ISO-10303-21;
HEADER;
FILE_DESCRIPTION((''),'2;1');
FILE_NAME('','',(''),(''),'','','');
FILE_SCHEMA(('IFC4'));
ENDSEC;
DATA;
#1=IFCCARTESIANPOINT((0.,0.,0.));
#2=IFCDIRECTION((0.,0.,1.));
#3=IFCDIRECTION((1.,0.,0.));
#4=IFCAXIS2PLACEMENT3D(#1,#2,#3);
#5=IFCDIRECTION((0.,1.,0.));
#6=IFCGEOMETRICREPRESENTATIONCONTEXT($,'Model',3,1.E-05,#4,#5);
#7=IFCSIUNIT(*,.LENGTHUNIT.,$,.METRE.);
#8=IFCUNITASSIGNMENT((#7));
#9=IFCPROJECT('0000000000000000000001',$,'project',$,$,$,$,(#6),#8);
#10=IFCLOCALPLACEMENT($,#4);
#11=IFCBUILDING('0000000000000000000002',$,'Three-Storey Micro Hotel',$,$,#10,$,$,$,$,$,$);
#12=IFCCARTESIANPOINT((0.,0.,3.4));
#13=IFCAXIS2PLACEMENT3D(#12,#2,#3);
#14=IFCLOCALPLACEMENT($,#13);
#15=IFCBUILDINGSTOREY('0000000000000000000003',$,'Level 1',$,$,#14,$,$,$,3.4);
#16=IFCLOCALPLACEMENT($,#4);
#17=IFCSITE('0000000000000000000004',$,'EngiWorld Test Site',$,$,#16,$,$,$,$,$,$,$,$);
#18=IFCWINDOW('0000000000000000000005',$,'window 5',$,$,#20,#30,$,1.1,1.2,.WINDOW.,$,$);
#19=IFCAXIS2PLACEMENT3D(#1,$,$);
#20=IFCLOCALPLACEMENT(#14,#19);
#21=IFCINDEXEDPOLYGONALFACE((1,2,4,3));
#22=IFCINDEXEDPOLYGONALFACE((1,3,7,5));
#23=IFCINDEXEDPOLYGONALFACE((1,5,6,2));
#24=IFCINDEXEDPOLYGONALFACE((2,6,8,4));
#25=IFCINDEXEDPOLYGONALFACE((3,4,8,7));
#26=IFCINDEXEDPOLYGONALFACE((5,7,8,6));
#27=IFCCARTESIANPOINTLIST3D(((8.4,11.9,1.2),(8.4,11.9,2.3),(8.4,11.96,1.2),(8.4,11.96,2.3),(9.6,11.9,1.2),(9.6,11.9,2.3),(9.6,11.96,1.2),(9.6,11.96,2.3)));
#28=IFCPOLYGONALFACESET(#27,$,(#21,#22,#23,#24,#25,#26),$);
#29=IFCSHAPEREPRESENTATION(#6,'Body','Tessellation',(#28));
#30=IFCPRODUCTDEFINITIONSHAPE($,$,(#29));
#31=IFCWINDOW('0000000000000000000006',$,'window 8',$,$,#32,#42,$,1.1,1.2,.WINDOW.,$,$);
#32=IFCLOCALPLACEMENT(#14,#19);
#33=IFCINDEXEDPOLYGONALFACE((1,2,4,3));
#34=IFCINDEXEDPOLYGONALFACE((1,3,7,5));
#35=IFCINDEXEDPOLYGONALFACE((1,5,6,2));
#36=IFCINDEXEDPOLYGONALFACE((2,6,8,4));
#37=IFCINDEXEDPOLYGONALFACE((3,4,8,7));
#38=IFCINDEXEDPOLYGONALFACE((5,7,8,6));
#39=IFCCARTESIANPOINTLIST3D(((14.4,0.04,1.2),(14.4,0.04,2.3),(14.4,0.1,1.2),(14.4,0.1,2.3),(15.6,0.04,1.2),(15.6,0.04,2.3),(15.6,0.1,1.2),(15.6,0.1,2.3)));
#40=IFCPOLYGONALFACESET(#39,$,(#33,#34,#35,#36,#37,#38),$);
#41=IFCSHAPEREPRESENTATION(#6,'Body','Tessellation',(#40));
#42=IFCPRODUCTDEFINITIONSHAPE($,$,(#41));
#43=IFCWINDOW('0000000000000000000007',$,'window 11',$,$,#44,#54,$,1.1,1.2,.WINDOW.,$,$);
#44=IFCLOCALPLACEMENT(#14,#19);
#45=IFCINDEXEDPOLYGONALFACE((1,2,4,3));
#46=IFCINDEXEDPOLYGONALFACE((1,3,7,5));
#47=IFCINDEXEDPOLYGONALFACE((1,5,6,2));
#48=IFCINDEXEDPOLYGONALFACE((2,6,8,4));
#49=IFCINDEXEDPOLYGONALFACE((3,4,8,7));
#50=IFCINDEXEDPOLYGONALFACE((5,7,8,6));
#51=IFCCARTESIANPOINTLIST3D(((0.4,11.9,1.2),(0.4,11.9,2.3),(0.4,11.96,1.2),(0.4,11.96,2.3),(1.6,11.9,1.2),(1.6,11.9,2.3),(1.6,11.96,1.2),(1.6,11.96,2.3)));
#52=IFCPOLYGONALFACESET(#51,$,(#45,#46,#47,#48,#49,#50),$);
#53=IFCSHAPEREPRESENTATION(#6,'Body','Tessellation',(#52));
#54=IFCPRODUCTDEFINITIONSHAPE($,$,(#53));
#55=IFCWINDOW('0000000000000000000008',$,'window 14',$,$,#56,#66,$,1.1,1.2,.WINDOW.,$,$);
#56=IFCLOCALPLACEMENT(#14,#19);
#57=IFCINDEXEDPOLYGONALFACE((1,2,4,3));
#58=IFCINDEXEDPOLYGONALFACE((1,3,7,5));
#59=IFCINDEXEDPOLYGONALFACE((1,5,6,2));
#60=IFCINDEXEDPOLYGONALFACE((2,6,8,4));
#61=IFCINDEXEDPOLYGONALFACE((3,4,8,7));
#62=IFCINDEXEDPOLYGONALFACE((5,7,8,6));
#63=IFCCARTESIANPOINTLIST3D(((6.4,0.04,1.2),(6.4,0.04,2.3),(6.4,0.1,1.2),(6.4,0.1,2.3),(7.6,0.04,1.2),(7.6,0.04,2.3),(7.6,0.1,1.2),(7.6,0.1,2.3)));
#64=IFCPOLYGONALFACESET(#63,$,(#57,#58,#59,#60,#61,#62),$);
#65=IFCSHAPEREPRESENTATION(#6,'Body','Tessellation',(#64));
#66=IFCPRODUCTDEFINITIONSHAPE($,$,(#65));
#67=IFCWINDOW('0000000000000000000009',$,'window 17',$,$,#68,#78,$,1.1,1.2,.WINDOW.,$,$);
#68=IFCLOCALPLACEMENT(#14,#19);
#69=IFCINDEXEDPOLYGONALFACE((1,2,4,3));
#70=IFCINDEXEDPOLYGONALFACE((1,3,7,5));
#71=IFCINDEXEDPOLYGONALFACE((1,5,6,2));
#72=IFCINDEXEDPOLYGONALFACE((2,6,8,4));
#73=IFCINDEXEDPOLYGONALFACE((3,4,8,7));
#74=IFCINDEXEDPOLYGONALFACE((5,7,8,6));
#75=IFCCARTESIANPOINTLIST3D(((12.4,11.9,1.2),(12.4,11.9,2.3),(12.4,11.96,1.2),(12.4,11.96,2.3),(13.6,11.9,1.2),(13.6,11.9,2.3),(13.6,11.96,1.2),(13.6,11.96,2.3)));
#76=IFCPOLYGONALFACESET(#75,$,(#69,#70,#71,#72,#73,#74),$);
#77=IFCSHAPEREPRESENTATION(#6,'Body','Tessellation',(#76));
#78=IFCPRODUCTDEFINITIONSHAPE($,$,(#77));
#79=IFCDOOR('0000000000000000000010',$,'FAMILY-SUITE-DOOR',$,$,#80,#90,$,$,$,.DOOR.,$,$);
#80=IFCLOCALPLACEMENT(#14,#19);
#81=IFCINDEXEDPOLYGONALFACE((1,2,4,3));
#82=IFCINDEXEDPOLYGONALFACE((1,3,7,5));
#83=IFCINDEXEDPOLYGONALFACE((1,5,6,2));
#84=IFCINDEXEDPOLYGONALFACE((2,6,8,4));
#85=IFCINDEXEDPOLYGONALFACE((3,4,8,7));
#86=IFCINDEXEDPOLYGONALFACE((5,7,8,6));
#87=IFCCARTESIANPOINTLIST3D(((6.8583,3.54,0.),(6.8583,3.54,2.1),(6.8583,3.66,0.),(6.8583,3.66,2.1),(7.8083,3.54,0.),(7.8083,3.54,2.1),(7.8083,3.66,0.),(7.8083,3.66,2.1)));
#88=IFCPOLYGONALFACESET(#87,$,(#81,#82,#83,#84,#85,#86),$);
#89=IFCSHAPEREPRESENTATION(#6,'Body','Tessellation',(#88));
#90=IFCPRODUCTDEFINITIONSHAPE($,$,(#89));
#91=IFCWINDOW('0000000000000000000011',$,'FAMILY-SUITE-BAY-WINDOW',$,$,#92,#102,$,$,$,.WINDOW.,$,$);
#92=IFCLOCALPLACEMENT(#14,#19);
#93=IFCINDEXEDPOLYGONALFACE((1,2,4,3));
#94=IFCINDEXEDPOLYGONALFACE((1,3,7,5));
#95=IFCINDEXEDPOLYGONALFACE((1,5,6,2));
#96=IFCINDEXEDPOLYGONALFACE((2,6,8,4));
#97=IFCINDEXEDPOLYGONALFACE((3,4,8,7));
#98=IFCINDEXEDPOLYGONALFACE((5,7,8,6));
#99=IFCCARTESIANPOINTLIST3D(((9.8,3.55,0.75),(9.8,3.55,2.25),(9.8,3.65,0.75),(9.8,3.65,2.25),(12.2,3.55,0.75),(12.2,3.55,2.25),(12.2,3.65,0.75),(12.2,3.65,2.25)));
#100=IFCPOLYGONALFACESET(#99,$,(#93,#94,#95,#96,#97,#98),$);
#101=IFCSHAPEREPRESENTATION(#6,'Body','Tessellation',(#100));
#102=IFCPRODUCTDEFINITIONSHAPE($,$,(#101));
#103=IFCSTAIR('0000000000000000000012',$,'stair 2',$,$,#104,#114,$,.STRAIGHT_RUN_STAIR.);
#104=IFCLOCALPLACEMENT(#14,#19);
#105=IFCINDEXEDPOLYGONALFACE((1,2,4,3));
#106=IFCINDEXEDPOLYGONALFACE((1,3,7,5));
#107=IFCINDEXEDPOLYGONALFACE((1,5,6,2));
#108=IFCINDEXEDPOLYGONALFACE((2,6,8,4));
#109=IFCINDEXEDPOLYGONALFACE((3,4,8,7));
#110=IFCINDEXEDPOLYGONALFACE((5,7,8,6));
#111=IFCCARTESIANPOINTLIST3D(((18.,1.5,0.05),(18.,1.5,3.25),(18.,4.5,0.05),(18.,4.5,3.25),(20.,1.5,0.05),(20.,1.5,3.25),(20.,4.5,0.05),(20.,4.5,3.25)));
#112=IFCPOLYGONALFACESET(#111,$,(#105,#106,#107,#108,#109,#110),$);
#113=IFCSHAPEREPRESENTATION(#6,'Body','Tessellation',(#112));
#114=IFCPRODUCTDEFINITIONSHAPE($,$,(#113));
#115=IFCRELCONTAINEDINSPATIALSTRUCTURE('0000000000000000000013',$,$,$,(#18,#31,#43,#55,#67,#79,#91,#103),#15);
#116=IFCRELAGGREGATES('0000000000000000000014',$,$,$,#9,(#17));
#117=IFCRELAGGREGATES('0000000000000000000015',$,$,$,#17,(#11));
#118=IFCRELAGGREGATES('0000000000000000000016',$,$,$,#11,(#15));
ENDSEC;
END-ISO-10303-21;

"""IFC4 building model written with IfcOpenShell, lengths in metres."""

from ifc_helpers import new_model, si_unit, direction, frame, origin, origin_with_axes, origin_2d, origin_2d_with_axis, place, context, project, spatial, rectangle, extrude, element, save


model = new_model("IFC4")

# Units and contexts
model_context = context("Model", 3, precision=1e-05, world=origin_with_axes(), true_north=direction((0.0, 1.0, 0.0)))
ifc_project = project(units=[si_unit("LENGTHUNIT", "METRE")], contexts=[model_context])

# Site, building, storey
site_placement = place(None, origin_with_axes())
site = spatial("IfcSite", under=ifc_project, at=site_placement, Name="EngiWorld Test Site")
building_placement = place(None, origin_with_axes())
building = spatial("IfcBuilding", under=site, at=building_placement, Name="Three-Storey Micro Hotel")
storey_placement = place(None, frame((0.0, 0.0, 3.4), z_axis=(0.0, 0.0, 1.0), x_axis=(1.0, 0.0, 0.0)))
storey = spatial("IfcBuildingStorey", under=building, at=storey_placement, Name="Level 1", Elevation=3.4)

# Windows
for number, where, z_axis, x_axis, name in (
    (1, (9.0, 11.93, 4.6), (0.0, 0.0, 1.0), (1.0, 0.0, 0.0), "window 5"),
    (2, (15.0, 0.07, 4.6), (0.0, 0.0, 1.0), (1.0, 0.0, 0.0), "window 8"),
    (3, (1.0, 11.93, 4.6), (0.0, 0.0, 1.0), (1.0, 0.0, 0.0), "window 11"),
    (4, (7.0, 0.07, 4.6), (0.0, 0.0, 1.0), (1.0, 0.0, 0.0), "window 14"),
    (5, (13.0, 11.93, 4.6), (0.0, 0.0, 1.0), (1.0, 0.0, 0.0), "window 17"),
):
    element("IfcWindow", number, at=place(None, frame(where, z_axis=z_axis, x_axis=x_axis)), inside=storey, Name=name, OverallHeight=1.1, OverallWidth=1.2, PredefinedType="WINDOW", context=model_context, shape_type="SweptSolid", body=[
        extrude(rectangle(XDim=1.2, YDim=0.06, at=origin_2d_with_axis()), origin_with_axes(), (0.0, 0.0, 1.0), 1.1),
    ])

# Door
door_placement = place(None, frame((7.3333, 3.6, 3.4)))
element("IfcDoor", 6, at=door_placement, inside=storey, Name="FAMILY-SUITE-DOOR", PredefinedType="DOOR", context=model_context, shape_type="SweptSolid", body=[
    extrude(rectangle(XDim=0.95, YDim=0.12, at=origin_2d()), origin(), (0.0, 0.0, 1.0), 2.1),
])

# Window
window_placement = place(None, frame((11.0, 3.6, 4.15)))
element("IfcWindow", 7, at=window_placement, inside=storey, Name="FAMILY-SUITE-BAY-WINDOW", PredefinedType="WINDOW", context=model_context, shape_type="SweptSolid", body=[
    extrude(rectangle(XDim=2.4, YDim=0.1, at=origin_2d()), origin(), (0.0, 0.0, 1.0), 1.5),
])

# Stair
stair_placement = place(None, frame((19.0, 3.0, 3.45), z_axis=(0.0, 0.0, 1.0), x_axis=(1.0, 0.0, 0.0)))
element("IfcStair", 8, at=stair_placement, inside=storey, Name="stair 2", PredefinedType="STRAIGHT_RUN_STAIR", context=model_context, shape_type="SweptSolid", body=[
    extrude(rectangle(XDim=2.0, YDim=3.0, at=origin_2d_with_axis()), origin_with_axes(), (0.0, 0.0, 1.0), 3.2),
])

save(model, "model.ifc")
